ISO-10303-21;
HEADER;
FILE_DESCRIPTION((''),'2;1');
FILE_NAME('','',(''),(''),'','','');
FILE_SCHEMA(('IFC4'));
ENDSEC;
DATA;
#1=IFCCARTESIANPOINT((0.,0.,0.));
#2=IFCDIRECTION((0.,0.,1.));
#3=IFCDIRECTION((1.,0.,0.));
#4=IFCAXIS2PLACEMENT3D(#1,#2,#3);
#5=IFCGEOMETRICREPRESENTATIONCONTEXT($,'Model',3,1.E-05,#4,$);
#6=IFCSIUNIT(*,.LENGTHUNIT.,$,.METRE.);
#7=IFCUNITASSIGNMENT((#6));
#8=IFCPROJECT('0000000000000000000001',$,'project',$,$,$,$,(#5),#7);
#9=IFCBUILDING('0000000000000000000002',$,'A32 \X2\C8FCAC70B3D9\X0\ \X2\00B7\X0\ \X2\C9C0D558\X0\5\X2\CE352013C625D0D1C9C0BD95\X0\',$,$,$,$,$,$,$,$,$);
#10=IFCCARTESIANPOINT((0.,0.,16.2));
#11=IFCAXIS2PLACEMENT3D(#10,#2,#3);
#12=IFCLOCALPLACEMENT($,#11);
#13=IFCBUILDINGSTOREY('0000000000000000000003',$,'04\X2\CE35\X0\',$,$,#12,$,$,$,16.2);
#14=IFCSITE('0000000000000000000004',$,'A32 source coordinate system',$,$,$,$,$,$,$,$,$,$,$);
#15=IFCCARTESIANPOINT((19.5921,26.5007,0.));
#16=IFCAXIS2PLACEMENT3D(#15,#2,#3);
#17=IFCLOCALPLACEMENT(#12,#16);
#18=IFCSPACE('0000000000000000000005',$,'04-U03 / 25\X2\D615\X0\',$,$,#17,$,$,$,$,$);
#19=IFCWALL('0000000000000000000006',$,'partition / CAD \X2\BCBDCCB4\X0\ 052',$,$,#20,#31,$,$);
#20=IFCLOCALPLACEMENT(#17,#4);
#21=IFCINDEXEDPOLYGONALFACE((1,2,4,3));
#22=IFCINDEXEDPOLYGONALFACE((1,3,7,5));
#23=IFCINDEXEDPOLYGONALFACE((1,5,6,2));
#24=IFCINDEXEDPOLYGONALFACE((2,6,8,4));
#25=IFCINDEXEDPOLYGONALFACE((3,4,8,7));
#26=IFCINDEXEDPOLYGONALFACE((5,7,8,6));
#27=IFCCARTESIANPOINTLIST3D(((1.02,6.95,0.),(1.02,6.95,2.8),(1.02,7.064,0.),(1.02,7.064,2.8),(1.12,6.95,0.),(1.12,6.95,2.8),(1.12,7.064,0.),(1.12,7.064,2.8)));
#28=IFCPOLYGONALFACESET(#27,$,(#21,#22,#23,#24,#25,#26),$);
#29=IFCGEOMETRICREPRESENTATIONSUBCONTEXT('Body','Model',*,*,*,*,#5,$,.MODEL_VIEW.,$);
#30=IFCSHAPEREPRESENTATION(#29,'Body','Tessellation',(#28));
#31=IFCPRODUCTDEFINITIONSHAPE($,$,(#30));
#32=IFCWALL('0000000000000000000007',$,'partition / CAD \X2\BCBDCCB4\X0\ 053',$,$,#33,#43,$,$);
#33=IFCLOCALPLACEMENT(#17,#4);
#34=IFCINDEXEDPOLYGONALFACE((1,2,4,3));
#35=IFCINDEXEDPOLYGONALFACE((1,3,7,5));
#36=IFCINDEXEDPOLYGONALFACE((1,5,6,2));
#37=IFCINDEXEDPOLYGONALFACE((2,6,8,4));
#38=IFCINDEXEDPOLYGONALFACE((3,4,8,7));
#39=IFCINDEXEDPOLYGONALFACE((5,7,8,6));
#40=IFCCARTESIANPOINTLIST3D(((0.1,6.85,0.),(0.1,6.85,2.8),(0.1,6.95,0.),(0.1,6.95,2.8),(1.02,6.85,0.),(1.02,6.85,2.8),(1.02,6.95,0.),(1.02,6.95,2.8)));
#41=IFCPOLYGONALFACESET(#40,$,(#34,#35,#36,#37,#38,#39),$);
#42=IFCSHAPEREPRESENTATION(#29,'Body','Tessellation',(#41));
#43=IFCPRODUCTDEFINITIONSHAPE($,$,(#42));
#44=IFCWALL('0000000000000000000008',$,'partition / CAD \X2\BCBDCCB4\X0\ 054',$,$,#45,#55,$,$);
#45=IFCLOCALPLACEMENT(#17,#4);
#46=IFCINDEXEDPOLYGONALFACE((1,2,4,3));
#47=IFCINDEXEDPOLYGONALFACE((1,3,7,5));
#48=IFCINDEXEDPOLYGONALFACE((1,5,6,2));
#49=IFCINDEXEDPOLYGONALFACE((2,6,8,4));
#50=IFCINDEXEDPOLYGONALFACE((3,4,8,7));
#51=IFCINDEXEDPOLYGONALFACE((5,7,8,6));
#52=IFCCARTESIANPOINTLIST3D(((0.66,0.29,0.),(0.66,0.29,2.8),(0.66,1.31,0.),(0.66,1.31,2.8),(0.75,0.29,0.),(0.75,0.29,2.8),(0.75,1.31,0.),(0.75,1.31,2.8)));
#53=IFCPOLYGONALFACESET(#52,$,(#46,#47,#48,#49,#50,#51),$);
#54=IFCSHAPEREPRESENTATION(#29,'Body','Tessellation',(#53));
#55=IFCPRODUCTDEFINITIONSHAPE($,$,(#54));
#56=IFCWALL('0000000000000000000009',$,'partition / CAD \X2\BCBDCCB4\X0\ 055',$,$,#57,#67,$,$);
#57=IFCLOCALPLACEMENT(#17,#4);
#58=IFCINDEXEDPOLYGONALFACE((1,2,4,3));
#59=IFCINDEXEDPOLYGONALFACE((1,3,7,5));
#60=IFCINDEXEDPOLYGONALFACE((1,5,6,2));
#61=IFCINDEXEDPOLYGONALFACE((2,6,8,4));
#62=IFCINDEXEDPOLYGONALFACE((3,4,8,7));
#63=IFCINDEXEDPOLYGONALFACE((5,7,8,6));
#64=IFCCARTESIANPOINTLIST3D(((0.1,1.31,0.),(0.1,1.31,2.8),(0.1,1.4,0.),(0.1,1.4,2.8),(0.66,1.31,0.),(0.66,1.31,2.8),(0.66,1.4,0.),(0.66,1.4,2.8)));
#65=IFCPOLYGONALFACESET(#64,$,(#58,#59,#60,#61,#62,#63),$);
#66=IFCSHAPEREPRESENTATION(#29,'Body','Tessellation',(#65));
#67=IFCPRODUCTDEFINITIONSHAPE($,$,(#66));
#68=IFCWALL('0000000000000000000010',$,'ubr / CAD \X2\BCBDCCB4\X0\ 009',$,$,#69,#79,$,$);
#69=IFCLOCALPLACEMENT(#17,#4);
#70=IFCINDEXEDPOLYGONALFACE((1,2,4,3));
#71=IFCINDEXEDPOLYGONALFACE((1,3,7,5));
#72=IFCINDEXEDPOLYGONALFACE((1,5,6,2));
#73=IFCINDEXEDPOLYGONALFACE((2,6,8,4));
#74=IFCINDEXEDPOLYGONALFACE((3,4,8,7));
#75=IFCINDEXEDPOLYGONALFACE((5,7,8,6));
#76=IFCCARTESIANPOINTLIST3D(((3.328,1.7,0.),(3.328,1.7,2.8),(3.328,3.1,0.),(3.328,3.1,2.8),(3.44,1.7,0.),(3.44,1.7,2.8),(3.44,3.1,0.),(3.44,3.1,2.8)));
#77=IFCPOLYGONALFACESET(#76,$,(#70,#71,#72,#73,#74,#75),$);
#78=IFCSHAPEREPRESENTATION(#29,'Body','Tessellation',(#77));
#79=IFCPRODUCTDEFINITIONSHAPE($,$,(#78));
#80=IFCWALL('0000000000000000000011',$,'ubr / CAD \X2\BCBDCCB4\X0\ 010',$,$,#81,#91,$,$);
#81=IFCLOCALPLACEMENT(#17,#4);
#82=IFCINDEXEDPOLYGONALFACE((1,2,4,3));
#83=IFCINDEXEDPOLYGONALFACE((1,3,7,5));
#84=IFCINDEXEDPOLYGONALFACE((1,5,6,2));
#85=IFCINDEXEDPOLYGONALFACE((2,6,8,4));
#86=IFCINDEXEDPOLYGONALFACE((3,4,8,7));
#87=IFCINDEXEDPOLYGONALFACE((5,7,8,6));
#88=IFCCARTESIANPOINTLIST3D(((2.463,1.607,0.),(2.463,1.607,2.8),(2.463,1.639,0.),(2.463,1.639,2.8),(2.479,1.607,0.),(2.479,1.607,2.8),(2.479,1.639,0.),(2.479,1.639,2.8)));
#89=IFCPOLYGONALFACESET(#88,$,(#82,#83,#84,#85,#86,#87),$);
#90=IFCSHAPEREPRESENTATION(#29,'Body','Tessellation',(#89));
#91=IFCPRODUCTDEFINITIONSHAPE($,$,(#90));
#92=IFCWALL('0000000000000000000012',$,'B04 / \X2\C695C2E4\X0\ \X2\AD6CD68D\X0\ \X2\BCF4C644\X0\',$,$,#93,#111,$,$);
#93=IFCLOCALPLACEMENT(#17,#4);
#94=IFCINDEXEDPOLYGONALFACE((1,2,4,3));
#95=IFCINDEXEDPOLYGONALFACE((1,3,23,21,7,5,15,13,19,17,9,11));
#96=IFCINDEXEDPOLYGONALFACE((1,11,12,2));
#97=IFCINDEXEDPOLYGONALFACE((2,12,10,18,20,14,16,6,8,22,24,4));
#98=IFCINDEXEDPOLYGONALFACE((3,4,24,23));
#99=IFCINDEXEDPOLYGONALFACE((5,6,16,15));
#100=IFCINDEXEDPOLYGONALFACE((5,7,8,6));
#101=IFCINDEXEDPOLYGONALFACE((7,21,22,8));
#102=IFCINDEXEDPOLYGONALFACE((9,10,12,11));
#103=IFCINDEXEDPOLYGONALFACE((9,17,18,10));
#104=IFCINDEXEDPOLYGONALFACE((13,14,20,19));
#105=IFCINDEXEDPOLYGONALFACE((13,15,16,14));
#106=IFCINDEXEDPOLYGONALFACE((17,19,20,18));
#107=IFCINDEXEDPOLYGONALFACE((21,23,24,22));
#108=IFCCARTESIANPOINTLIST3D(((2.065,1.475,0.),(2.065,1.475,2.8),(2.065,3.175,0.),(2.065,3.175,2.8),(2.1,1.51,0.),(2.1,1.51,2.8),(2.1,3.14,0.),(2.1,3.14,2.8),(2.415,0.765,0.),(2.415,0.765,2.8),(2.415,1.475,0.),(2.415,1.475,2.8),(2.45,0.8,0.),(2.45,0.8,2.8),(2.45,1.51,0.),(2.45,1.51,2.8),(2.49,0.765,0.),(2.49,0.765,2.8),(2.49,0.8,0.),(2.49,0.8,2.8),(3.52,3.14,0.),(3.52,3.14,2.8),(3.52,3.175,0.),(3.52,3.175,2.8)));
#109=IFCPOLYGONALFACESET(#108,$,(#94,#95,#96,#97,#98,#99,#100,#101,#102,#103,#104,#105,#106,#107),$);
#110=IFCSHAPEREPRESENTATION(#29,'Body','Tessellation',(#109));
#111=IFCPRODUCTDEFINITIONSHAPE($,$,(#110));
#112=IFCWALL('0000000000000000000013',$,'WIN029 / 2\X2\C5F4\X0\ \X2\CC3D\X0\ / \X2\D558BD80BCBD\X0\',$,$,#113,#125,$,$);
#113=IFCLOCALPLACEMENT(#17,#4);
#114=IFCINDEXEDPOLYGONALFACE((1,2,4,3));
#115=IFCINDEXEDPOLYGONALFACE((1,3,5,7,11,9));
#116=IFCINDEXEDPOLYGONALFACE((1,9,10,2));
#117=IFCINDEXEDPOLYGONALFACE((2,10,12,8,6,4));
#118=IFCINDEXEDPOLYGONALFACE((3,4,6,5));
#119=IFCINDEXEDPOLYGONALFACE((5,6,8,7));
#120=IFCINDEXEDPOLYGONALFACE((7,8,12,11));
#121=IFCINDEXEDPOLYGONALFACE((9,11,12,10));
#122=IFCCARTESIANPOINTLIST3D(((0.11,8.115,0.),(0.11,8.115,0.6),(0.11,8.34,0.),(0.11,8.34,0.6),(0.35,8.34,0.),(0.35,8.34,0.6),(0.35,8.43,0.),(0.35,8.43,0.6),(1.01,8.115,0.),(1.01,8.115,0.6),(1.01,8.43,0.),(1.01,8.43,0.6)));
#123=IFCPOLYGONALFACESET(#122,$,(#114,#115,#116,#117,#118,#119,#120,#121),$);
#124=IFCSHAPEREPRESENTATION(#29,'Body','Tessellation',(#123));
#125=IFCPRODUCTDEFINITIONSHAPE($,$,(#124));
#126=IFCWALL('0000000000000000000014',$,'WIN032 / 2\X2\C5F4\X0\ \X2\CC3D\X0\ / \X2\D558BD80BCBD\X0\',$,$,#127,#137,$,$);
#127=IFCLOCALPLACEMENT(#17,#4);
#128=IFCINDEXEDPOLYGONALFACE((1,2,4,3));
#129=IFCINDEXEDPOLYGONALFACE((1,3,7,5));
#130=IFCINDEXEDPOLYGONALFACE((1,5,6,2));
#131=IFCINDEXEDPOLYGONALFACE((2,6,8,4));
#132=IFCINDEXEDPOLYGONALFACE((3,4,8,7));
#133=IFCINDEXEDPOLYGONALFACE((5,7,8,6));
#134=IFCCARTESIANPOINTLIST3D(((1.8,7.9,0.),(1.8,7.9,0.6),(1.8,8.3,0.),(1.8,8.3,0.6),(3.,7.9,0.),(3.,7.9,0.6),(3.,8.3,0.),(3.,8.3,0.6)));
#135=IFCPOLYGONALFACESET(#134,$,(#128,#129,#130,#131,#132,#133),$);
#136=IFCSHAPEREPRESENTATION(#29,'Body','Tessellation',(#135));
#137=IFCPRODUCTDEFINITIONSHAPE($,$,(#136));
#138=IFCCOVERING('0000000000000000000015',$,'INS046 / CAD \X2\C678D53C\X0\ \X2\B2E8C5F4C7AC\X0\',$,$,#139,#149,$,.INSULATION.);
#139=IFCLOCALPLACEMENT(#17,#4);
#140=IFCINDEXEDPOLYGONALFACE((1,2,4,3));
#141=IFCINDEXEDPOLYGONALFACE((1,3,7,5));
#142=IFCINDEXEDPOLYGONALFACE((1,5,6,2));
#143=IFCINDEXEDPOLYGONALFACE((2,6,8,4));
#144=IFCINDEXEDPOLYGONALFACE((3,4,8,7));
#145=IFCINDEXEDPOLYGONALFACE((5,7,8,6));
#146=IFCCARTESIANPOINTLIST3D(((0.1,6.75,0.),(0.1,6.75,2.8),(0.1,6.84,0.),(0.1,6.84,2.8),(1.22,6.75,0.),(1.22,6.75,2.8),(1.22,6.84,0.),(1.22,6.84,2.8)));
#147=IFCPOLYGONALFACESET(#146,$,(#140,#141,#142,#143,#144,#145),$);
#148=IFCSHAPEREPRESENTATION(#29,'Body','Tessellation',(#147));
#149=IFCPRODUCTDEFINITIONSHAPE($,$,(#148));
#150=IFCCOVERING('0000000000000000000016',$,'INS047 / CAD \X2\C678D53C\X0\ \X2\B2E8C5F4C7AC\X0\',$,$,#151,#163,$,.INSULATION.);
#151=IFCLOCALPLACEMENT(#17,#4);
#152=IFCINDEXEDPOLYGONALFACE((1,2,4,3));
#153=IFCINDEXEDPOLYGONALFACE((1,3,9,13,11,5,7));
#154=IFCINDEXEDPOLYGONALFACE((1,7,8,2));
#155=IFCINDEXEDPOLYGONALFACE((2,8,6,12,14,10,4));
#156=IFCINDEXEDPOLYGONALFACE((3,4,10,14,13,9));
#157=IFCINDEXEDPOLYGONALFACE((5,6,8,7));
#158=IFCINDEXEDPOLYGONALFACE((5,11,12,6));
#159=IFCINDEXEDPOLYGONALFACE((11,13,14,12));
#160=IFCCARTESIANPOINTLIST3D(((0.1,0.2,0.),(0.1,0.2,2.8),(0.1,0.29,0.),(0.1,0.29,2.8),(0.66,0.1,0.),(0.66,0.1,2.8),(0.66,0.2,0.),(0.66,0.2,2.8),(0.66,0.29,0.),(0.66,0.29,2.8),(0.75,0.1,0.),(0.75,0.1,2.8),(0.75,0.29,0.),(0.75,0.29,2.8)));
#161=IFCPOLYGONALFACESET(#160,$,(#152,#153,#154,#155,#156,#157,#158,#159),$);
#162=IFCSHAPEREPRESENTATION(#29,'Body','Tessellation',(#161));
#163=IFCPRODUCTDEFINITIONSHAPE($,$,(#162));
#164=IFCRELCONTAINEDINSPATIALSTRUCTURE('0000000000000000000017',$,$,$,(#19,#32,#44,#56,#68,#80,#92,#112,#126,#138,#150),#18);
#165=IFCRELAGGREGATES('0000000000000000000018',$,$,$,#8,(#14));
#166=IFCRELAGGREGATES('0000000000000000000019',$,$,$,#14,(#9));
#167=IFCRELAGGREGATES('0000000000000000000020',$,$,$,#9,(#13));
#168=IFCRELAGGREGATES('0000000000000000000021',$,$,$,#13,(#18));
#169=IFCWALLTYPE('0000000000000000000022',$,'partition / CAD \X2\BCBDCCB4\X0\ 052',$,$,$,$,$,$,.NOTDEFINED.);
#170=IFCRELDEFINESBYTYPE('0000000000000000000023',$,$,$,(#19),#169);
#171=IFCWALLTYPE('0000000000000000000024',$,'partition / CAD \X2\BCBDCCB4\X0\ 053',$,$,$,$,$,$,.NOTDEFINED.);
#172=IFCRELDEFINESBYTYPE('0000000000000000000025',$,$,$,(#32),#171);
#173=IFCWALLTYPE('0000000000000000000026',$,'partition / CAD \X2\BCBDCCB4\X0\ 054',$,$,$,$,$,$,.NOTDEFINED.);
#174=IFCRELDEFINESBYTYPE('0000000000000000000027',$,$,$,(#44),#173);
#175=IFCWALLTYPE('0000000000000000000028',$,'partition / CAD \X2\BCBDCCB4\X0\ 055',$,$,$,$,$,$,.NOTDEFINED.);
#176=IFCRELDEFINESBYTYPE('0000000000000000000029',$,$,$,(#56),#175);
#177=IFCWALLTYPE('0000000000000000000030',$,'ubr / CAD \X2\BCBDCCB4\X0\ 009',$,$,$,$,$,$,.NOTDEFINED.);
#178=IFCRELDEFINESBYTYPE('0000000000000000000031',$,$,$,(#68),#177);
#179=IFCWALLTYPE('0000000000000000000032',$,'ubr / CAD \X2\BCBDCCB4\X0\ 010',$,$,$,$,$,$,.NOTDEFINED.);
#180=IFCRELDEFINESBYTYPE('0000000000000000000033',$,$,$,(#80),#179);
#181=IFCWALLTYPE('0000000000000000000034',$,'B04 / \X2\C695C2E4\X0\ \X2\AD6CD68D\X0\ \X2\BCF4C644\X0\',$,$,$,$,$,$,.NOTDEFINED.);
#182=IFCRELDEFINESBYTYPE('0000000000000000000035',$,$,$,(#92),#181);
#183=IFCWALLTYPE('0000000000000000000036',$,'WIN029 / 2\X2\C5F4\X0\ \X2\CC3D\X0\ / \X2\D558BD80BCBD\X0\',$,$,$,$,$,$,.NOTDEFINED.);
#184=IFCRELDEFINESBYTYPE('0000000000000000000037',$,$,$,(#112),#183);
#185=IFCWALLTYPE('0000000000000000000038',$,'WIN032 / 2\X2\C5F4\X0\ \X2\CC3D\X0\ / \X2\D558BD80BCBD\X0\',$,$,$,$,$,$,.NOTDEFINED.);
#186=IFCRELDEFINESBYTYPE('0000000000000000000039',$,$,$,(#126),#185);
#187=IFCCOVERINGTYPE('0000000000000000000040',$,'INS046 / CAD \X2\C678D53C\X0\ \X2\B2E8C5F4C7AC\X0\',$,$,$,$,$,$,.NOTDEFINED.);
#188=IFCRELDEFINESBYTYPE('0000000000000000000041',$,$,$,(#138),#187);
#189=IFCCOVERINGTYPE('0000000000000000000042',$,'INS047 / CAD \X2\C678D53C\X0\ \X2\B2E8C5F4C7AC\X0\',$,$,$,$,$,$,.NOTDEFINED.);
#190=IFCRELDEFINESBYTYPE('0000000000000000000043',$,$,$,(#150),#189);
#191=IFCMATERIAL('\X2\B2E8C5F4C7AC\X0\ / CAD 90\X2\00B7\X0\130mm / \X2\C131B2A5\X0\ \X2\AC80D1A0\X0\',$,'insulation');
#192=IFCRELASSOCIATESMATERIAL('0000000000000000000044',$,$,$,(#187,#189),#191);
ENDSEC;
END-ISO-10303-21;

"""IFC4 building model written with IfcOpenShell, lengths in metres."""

from ifc_helpers import new_model, si_unit, frame, origin, origin_with_axes, place, context, subcontext, project, spatial, polyline, outline, extrude, source, transform, mapped, material, type_object, type_shapes, element, save


model = new_model("IFC4")

# Units and contexts
model_context = context("Model", 3, precision=1e-05, world=origin_with_axes())
body_context = subcontext(model_context, "Body", "Model", "MODEL_VIEW")
ifc_project = project(units=[si_unit("LENGTHUNIT", "METRE")], contexts=[model_context])

# Site, building, storey, space
storey_placement = place(None, frame((0.0, 0.0, 16.2), z_axis=(0.0, 0.0, 1.0), x_axis=(1.0, 0.0, 0.0)))
space_placement = place(storey_placement, frame((19.5921, 26.5007, 0.0), z_axis=(0.0, 0.0, 1.0), x_axis=(1.0, 0.0, 0.0)))
site = spatial("IfcSite", under=ifc_project, Name="A32 source coordinate system")
building = spatial("IfcBuilding", under=site, Name="A32 주거동 · 지하5층–옥탑지붕")
storey = spatial("IfcBuildingStorey", under=building, at=storey_placement, Name="04층", Elevation=16.2)
space = spatial("IfcSpace", under=storey, at=space_placement, Name="04-U03 / 25형")

# Walls
wall_type_1 = type_object("IfcWallType", Name="partition / CAD 벽체 052", PredefinedType="NOTDEFINED")
shared_shape_1 = source(origin(), body_context, "Body", "SweptSolid", [
    extrude(outline(polyline([(1.12, 6.95), (1.02, 6.95), (1.02, 7.064), (1.12, 7.064), (1.12, 6.95)])), origin(), (0.0, 0.0, 1.0), 2.8),
])
type_shapes(wall_type_1, [shared_shape_1])
wall_1_placement = place(space_placement, origin_with_axes())
element("IfcWall", 1, at=wall_1_placement, inside=space, type_object=wall_type_1, Name="partition / CAD 벽체 052", context=body_context, shape_type="MappedRepresentation", body=[
    mapped(shared_shape_1, transform((0.0, 0.0, 0.0), scale=1.0)),
])
wall_type_2 = type_object("IfcWallType", Name="partition / CAD 벽체 053", PredefinedType="NOTDEFINED")
shared_shape_2 = source(origin(), body_context, "Body", "SweptSolid", [
    extrude(outline(polyline([(1.02, 6.95), (1.02, 6.85), (0.1, 6.85), (0.1, 6.95), (1.02, 6.95)])), origin(), (0.0, 0.0, 1.0), 2.8),
])
type_shapes(wall_type_2, [shared_shape_2])
wall_2_placement = place(space_placement, origin_with_axes())
element("IfcWall", 2, at=wall_2_placement, inside=space, type_object=wall_type_2, Name="partition / CAD 벽체 053", context=body_context, shape_type="MappedRepresentation", body=[
    mapped(shared_shape_2, transform((0.0, 0.0, 0.0), scale=1.0)),
])
wall_type_3 = type_object("IfcWallType", Name="partition / CAD 벽체 054", PredefinedType="NOTDEFINED")
shared_shape_3 = source(origin(), body_context, "Body", "SweptSolid", [
    extrude(outline(polyline([(0.75, 0.29), (0.66, 0.29), (0.66, 1.31), (0.75, 1.31), (0.75, 0.29)])), origin(), (0.0, 0.0, 1.0), 2.8),
])
type_shapes(wall_type_3, [shared_shape_3])
wall_3_placement = place(space_placement, origin_with_axes())
element("IfcWall", 3, at=wall_3_placement, inside=space, type_object=wall_type_3, Name="partition / CAD 벽체 054", context=body_context, shape_type="MappedRepresentation", body=[
    mapped(shared_shape_3, transform((0.0, 0.0, 0.0), scale=1.0)),
])
wall_type_4 = type_object("IfcWallType", Name="partition / CAD 벽체 055", PredefinedType="NOTDEFINED")
shared_shape_4 = source(origin(), body_context, "Body", "SweptSolid", [
    extrude(outline(polyline([(0.66, 1.4), (0.66, 1.31), (0.1, 1.31), (0.1, 1.4), (0.66, 1.4)])), origin(), (0.0, 0.0, 1.0), 2.8),
])
type_shapes(wall_type_4, [shared_shape_4])
wall_4_placement = place(space_placement, origin_with_axes())
element("IfcWall", 4, at=wall_4_placement, inside=space, type_object=wall_type_4, Name="partition / CAD 벽체 055", context=body_context, shape_type="MappedRepresentation", body=[
    mapped(shared_shape_4, transform((0.0, 0.0, 0.0), scale=1.0)),
])
wall_type_5 = type_object("IfcWallType", Name="ubr / CAD 벽체 009", PredefinedType="NOTDEFINED")
shared_shape_5 = source(origin(), body_context, "Body", "SweptSolid", [
    extrude(outline(polyline([(3.328, 3.1), (3.44, 3.1), (3.44, 1.7), (3.328, 1.7), (3.328, 3.1)])), origin(), (0.0, 0.0, 1.0), 2.8),
])
type_shapes(wall_type_5, [shared_shape_5])
wall_5_placement = place(space_placement, origin_with_axes())
element("IfcWall", 5, at=wall_5_placement, inside=space, type_object=wall_type_5, Name="ubr / CAD 벽체 009", context=body_context, shape_type="MappedRepresentation", body=[
    mapped(shared_shape_5, transform((0.0, 0.0, 0.0), scale=1.0)),
])
wall_type_6 = type_object("IfcWallType", Name="ubr / CAD 벽체 010", PredefinedType="NOTDEFINED")
shared_shape_6 = source(origin(), body_context, "Body", "SweptSolid", [
    extrude(outline(polyline([(2.463, 1.607), (2.463, 1.639), (2.479, 1.639), (2.479, 1.607), (2.463, 1.607)])), origin(), (0.0, 0.0, 1.0), 2.8),
])
type_shapes(wall_type_6, [shared_shape_6])
wall_6_placement = place(space_placement, origin_with_axes())
element("IfcWall", 6, at=wall_6_placement, inside=space, type_object=wall_type_6, Name="ubr / CAD 벽체 010", context=body_context, shape_type="MappedRepresentation", body=[
    mapped(shared_shape_6, transform((0.0, 0.0, 0.0), scale=1.0)),
])
wall_type_7 = type_object("IfcWallType", Name="B04 / 욕실 구획 보완", PredefinedType="NOTDEFINED")
shared_shape_7 = source(origin(), body_context, "Body", "SweptSolid", [
    extrude(outline(polyline([(3.52, 3.175), (3.52, 3.14), (2.1, 3.14), (2.1, 1.51), (2.45, 1.51), (2.45, 0.8), (2.49, 0.8), (2.49, 0.765), (2.415, 0.765), (2.415, 1.475), (2.065, 1.475), (2.065, 3.175), (3.52, 3.175)])), origin(), (0.0, 0.0, 1.0), 2.8),
])
type_shapes(wall_type_7, [shared_shape_7])
wall_7_placement = place(space_placement, origin_with_axes())
element("IfcWall", 7, at=wall_7_placement, inside=space, type_object=wall_type_7, Name="B04 / 욕실 구획 보완", context=body_context, shape_type="MappedRepresentation", body=[
    mapped(shared_shape_7, transform((0.0, 0.0, 0.0), scale=1.0)),
])
wall_type_8 = type_object("IfcWallType", Name="WIN029 / 2열 창 / 하부벽", PredefinedType="NOTDEFINED")
shared_shape_8 = source(origin(), body_context, "Body", "SweptSolid", [
    extrude(outline(polyline([(1.01, 8.115), (0.11, 8.115), (0.11, 8.34), (0.35, 8.34), (0.35, 8.43), (1.01, 8.43), (1.01, 8.115)])), origin(), (0.0, 0.0, 1.0), 0.6),
])
type_shapes(wall_type_8, [shared_shape_8])
wall_8_placement = place(space_placement, origin_with_axes())
element("IfcWall", 8, at=wall_8_placement, inside=space, type_object=wall_type_8, Name="WIN029 / 2열 창 / 하부벽", context=body_context, shape_type="MappedRepresentation", body=[
    mapped(shared_shape_8, transform((0.0, 0.0, 0.0), scale=1.0)),
])
wall_type_9 = type_object("IfcWallType", Name="WIN032 / 2열 창 / 하부벽", PredefinedType="NOTDEFINED")
shared_shape_9 = source(origin(), body_context, "Body", "SweptSolid", [
    extrude(outline(polyline([(3.0, 7.9), (1.8, 7.9), (1.8, 8.3), (3.0, 8.3), (3.0, 7.9)])), origin(), (0.0, 0.0, 1.0), 0.6),
])
type_shapes(wall_type_9, [shared_shape_9])
wall_9_placement = place(space_placement, origin_with_axes())
element("IfcWall", 9, at=wall_9_placement, inside=space, type_object=wall_type_9, Name="WIN032 / 2열 창 / 하부벽", context=body_context, shape_type="MappedRepresentation", body=[
    mapped(shared_shape_9, transform((0.0, 0.0, 0.0), scale=1.0)),
])

# Coverings
ifc_material = material(Name="단열재 / CAD 90·130mm / 성능 검토", Category="insulation")
covering_type_1 = type_object("IfcCoveringType", Name="INS046 / CAD 외피 단열재", PredefinedType="NOTDEFINED", material=ifc_material)
shared_shape_10 = source(origin(), body_context, "Body", "SweptSolid", [
    extrude(outline(polyline([(0.1, 6.84), (1.22, 6.84), (1.22, 6.75), (0.1, 6.75), (0.1, 6.84)])), origin(), (0.0, 0.0, 1.0), 2.8),
])
type_shapes(covering_type_1, [shared_shape_10])
covering_1_placement = place(space_placement, origin_with_axes())
element("IfcCovering", 10, at=covering_1_placement, inside=space, type_object=covering_type_1, Name="INS046 / CAD 외피 단열재", PredefinedType="INSULATION", context=body_context, shape_type="MappedRepresentation", body=[
    mapped(shared_shape_10, transform((0.0, 0.0, 0.0), scale=1.0)),
])
covering_type_2 = type_object("IfcCoveringType", Name="INS047 / CAD 외피 단열재", PredefinedType="NOTDEFINED", material=ifc_material)
shared_shape_11 = source(origin(), body_context, "Body", "SweptSolid", [
    extrude(outline(polyline([(0.1, 0.2), (0.1, 0.29), (0.66, 0.29), (0.75, 0.29), (0.75, 0.1), (0.66, 0.1), (0.66, 0.2), (0.1, 0.2)])), origin(), (0.0, 0.0, 1.0), 2.8),
])
type_shapes(covering_type_2, [shared_shape_11])
covering_2_placement = place(space_placement, origin_with_axes())
element("IfcCovering", 11, at=covering_2_placement, inside=space, type_object=covering_type_2, Name="INS047 / CAD 외피 단열재", PredefinedType="INSULATION", context=body_context, shape_type="MappedRepresentation", body=[
    mapped(shared_shape_11, transform((0.0, 0.0, 0.0), scale=1.0)),
])

save(model, "model.ifc")
